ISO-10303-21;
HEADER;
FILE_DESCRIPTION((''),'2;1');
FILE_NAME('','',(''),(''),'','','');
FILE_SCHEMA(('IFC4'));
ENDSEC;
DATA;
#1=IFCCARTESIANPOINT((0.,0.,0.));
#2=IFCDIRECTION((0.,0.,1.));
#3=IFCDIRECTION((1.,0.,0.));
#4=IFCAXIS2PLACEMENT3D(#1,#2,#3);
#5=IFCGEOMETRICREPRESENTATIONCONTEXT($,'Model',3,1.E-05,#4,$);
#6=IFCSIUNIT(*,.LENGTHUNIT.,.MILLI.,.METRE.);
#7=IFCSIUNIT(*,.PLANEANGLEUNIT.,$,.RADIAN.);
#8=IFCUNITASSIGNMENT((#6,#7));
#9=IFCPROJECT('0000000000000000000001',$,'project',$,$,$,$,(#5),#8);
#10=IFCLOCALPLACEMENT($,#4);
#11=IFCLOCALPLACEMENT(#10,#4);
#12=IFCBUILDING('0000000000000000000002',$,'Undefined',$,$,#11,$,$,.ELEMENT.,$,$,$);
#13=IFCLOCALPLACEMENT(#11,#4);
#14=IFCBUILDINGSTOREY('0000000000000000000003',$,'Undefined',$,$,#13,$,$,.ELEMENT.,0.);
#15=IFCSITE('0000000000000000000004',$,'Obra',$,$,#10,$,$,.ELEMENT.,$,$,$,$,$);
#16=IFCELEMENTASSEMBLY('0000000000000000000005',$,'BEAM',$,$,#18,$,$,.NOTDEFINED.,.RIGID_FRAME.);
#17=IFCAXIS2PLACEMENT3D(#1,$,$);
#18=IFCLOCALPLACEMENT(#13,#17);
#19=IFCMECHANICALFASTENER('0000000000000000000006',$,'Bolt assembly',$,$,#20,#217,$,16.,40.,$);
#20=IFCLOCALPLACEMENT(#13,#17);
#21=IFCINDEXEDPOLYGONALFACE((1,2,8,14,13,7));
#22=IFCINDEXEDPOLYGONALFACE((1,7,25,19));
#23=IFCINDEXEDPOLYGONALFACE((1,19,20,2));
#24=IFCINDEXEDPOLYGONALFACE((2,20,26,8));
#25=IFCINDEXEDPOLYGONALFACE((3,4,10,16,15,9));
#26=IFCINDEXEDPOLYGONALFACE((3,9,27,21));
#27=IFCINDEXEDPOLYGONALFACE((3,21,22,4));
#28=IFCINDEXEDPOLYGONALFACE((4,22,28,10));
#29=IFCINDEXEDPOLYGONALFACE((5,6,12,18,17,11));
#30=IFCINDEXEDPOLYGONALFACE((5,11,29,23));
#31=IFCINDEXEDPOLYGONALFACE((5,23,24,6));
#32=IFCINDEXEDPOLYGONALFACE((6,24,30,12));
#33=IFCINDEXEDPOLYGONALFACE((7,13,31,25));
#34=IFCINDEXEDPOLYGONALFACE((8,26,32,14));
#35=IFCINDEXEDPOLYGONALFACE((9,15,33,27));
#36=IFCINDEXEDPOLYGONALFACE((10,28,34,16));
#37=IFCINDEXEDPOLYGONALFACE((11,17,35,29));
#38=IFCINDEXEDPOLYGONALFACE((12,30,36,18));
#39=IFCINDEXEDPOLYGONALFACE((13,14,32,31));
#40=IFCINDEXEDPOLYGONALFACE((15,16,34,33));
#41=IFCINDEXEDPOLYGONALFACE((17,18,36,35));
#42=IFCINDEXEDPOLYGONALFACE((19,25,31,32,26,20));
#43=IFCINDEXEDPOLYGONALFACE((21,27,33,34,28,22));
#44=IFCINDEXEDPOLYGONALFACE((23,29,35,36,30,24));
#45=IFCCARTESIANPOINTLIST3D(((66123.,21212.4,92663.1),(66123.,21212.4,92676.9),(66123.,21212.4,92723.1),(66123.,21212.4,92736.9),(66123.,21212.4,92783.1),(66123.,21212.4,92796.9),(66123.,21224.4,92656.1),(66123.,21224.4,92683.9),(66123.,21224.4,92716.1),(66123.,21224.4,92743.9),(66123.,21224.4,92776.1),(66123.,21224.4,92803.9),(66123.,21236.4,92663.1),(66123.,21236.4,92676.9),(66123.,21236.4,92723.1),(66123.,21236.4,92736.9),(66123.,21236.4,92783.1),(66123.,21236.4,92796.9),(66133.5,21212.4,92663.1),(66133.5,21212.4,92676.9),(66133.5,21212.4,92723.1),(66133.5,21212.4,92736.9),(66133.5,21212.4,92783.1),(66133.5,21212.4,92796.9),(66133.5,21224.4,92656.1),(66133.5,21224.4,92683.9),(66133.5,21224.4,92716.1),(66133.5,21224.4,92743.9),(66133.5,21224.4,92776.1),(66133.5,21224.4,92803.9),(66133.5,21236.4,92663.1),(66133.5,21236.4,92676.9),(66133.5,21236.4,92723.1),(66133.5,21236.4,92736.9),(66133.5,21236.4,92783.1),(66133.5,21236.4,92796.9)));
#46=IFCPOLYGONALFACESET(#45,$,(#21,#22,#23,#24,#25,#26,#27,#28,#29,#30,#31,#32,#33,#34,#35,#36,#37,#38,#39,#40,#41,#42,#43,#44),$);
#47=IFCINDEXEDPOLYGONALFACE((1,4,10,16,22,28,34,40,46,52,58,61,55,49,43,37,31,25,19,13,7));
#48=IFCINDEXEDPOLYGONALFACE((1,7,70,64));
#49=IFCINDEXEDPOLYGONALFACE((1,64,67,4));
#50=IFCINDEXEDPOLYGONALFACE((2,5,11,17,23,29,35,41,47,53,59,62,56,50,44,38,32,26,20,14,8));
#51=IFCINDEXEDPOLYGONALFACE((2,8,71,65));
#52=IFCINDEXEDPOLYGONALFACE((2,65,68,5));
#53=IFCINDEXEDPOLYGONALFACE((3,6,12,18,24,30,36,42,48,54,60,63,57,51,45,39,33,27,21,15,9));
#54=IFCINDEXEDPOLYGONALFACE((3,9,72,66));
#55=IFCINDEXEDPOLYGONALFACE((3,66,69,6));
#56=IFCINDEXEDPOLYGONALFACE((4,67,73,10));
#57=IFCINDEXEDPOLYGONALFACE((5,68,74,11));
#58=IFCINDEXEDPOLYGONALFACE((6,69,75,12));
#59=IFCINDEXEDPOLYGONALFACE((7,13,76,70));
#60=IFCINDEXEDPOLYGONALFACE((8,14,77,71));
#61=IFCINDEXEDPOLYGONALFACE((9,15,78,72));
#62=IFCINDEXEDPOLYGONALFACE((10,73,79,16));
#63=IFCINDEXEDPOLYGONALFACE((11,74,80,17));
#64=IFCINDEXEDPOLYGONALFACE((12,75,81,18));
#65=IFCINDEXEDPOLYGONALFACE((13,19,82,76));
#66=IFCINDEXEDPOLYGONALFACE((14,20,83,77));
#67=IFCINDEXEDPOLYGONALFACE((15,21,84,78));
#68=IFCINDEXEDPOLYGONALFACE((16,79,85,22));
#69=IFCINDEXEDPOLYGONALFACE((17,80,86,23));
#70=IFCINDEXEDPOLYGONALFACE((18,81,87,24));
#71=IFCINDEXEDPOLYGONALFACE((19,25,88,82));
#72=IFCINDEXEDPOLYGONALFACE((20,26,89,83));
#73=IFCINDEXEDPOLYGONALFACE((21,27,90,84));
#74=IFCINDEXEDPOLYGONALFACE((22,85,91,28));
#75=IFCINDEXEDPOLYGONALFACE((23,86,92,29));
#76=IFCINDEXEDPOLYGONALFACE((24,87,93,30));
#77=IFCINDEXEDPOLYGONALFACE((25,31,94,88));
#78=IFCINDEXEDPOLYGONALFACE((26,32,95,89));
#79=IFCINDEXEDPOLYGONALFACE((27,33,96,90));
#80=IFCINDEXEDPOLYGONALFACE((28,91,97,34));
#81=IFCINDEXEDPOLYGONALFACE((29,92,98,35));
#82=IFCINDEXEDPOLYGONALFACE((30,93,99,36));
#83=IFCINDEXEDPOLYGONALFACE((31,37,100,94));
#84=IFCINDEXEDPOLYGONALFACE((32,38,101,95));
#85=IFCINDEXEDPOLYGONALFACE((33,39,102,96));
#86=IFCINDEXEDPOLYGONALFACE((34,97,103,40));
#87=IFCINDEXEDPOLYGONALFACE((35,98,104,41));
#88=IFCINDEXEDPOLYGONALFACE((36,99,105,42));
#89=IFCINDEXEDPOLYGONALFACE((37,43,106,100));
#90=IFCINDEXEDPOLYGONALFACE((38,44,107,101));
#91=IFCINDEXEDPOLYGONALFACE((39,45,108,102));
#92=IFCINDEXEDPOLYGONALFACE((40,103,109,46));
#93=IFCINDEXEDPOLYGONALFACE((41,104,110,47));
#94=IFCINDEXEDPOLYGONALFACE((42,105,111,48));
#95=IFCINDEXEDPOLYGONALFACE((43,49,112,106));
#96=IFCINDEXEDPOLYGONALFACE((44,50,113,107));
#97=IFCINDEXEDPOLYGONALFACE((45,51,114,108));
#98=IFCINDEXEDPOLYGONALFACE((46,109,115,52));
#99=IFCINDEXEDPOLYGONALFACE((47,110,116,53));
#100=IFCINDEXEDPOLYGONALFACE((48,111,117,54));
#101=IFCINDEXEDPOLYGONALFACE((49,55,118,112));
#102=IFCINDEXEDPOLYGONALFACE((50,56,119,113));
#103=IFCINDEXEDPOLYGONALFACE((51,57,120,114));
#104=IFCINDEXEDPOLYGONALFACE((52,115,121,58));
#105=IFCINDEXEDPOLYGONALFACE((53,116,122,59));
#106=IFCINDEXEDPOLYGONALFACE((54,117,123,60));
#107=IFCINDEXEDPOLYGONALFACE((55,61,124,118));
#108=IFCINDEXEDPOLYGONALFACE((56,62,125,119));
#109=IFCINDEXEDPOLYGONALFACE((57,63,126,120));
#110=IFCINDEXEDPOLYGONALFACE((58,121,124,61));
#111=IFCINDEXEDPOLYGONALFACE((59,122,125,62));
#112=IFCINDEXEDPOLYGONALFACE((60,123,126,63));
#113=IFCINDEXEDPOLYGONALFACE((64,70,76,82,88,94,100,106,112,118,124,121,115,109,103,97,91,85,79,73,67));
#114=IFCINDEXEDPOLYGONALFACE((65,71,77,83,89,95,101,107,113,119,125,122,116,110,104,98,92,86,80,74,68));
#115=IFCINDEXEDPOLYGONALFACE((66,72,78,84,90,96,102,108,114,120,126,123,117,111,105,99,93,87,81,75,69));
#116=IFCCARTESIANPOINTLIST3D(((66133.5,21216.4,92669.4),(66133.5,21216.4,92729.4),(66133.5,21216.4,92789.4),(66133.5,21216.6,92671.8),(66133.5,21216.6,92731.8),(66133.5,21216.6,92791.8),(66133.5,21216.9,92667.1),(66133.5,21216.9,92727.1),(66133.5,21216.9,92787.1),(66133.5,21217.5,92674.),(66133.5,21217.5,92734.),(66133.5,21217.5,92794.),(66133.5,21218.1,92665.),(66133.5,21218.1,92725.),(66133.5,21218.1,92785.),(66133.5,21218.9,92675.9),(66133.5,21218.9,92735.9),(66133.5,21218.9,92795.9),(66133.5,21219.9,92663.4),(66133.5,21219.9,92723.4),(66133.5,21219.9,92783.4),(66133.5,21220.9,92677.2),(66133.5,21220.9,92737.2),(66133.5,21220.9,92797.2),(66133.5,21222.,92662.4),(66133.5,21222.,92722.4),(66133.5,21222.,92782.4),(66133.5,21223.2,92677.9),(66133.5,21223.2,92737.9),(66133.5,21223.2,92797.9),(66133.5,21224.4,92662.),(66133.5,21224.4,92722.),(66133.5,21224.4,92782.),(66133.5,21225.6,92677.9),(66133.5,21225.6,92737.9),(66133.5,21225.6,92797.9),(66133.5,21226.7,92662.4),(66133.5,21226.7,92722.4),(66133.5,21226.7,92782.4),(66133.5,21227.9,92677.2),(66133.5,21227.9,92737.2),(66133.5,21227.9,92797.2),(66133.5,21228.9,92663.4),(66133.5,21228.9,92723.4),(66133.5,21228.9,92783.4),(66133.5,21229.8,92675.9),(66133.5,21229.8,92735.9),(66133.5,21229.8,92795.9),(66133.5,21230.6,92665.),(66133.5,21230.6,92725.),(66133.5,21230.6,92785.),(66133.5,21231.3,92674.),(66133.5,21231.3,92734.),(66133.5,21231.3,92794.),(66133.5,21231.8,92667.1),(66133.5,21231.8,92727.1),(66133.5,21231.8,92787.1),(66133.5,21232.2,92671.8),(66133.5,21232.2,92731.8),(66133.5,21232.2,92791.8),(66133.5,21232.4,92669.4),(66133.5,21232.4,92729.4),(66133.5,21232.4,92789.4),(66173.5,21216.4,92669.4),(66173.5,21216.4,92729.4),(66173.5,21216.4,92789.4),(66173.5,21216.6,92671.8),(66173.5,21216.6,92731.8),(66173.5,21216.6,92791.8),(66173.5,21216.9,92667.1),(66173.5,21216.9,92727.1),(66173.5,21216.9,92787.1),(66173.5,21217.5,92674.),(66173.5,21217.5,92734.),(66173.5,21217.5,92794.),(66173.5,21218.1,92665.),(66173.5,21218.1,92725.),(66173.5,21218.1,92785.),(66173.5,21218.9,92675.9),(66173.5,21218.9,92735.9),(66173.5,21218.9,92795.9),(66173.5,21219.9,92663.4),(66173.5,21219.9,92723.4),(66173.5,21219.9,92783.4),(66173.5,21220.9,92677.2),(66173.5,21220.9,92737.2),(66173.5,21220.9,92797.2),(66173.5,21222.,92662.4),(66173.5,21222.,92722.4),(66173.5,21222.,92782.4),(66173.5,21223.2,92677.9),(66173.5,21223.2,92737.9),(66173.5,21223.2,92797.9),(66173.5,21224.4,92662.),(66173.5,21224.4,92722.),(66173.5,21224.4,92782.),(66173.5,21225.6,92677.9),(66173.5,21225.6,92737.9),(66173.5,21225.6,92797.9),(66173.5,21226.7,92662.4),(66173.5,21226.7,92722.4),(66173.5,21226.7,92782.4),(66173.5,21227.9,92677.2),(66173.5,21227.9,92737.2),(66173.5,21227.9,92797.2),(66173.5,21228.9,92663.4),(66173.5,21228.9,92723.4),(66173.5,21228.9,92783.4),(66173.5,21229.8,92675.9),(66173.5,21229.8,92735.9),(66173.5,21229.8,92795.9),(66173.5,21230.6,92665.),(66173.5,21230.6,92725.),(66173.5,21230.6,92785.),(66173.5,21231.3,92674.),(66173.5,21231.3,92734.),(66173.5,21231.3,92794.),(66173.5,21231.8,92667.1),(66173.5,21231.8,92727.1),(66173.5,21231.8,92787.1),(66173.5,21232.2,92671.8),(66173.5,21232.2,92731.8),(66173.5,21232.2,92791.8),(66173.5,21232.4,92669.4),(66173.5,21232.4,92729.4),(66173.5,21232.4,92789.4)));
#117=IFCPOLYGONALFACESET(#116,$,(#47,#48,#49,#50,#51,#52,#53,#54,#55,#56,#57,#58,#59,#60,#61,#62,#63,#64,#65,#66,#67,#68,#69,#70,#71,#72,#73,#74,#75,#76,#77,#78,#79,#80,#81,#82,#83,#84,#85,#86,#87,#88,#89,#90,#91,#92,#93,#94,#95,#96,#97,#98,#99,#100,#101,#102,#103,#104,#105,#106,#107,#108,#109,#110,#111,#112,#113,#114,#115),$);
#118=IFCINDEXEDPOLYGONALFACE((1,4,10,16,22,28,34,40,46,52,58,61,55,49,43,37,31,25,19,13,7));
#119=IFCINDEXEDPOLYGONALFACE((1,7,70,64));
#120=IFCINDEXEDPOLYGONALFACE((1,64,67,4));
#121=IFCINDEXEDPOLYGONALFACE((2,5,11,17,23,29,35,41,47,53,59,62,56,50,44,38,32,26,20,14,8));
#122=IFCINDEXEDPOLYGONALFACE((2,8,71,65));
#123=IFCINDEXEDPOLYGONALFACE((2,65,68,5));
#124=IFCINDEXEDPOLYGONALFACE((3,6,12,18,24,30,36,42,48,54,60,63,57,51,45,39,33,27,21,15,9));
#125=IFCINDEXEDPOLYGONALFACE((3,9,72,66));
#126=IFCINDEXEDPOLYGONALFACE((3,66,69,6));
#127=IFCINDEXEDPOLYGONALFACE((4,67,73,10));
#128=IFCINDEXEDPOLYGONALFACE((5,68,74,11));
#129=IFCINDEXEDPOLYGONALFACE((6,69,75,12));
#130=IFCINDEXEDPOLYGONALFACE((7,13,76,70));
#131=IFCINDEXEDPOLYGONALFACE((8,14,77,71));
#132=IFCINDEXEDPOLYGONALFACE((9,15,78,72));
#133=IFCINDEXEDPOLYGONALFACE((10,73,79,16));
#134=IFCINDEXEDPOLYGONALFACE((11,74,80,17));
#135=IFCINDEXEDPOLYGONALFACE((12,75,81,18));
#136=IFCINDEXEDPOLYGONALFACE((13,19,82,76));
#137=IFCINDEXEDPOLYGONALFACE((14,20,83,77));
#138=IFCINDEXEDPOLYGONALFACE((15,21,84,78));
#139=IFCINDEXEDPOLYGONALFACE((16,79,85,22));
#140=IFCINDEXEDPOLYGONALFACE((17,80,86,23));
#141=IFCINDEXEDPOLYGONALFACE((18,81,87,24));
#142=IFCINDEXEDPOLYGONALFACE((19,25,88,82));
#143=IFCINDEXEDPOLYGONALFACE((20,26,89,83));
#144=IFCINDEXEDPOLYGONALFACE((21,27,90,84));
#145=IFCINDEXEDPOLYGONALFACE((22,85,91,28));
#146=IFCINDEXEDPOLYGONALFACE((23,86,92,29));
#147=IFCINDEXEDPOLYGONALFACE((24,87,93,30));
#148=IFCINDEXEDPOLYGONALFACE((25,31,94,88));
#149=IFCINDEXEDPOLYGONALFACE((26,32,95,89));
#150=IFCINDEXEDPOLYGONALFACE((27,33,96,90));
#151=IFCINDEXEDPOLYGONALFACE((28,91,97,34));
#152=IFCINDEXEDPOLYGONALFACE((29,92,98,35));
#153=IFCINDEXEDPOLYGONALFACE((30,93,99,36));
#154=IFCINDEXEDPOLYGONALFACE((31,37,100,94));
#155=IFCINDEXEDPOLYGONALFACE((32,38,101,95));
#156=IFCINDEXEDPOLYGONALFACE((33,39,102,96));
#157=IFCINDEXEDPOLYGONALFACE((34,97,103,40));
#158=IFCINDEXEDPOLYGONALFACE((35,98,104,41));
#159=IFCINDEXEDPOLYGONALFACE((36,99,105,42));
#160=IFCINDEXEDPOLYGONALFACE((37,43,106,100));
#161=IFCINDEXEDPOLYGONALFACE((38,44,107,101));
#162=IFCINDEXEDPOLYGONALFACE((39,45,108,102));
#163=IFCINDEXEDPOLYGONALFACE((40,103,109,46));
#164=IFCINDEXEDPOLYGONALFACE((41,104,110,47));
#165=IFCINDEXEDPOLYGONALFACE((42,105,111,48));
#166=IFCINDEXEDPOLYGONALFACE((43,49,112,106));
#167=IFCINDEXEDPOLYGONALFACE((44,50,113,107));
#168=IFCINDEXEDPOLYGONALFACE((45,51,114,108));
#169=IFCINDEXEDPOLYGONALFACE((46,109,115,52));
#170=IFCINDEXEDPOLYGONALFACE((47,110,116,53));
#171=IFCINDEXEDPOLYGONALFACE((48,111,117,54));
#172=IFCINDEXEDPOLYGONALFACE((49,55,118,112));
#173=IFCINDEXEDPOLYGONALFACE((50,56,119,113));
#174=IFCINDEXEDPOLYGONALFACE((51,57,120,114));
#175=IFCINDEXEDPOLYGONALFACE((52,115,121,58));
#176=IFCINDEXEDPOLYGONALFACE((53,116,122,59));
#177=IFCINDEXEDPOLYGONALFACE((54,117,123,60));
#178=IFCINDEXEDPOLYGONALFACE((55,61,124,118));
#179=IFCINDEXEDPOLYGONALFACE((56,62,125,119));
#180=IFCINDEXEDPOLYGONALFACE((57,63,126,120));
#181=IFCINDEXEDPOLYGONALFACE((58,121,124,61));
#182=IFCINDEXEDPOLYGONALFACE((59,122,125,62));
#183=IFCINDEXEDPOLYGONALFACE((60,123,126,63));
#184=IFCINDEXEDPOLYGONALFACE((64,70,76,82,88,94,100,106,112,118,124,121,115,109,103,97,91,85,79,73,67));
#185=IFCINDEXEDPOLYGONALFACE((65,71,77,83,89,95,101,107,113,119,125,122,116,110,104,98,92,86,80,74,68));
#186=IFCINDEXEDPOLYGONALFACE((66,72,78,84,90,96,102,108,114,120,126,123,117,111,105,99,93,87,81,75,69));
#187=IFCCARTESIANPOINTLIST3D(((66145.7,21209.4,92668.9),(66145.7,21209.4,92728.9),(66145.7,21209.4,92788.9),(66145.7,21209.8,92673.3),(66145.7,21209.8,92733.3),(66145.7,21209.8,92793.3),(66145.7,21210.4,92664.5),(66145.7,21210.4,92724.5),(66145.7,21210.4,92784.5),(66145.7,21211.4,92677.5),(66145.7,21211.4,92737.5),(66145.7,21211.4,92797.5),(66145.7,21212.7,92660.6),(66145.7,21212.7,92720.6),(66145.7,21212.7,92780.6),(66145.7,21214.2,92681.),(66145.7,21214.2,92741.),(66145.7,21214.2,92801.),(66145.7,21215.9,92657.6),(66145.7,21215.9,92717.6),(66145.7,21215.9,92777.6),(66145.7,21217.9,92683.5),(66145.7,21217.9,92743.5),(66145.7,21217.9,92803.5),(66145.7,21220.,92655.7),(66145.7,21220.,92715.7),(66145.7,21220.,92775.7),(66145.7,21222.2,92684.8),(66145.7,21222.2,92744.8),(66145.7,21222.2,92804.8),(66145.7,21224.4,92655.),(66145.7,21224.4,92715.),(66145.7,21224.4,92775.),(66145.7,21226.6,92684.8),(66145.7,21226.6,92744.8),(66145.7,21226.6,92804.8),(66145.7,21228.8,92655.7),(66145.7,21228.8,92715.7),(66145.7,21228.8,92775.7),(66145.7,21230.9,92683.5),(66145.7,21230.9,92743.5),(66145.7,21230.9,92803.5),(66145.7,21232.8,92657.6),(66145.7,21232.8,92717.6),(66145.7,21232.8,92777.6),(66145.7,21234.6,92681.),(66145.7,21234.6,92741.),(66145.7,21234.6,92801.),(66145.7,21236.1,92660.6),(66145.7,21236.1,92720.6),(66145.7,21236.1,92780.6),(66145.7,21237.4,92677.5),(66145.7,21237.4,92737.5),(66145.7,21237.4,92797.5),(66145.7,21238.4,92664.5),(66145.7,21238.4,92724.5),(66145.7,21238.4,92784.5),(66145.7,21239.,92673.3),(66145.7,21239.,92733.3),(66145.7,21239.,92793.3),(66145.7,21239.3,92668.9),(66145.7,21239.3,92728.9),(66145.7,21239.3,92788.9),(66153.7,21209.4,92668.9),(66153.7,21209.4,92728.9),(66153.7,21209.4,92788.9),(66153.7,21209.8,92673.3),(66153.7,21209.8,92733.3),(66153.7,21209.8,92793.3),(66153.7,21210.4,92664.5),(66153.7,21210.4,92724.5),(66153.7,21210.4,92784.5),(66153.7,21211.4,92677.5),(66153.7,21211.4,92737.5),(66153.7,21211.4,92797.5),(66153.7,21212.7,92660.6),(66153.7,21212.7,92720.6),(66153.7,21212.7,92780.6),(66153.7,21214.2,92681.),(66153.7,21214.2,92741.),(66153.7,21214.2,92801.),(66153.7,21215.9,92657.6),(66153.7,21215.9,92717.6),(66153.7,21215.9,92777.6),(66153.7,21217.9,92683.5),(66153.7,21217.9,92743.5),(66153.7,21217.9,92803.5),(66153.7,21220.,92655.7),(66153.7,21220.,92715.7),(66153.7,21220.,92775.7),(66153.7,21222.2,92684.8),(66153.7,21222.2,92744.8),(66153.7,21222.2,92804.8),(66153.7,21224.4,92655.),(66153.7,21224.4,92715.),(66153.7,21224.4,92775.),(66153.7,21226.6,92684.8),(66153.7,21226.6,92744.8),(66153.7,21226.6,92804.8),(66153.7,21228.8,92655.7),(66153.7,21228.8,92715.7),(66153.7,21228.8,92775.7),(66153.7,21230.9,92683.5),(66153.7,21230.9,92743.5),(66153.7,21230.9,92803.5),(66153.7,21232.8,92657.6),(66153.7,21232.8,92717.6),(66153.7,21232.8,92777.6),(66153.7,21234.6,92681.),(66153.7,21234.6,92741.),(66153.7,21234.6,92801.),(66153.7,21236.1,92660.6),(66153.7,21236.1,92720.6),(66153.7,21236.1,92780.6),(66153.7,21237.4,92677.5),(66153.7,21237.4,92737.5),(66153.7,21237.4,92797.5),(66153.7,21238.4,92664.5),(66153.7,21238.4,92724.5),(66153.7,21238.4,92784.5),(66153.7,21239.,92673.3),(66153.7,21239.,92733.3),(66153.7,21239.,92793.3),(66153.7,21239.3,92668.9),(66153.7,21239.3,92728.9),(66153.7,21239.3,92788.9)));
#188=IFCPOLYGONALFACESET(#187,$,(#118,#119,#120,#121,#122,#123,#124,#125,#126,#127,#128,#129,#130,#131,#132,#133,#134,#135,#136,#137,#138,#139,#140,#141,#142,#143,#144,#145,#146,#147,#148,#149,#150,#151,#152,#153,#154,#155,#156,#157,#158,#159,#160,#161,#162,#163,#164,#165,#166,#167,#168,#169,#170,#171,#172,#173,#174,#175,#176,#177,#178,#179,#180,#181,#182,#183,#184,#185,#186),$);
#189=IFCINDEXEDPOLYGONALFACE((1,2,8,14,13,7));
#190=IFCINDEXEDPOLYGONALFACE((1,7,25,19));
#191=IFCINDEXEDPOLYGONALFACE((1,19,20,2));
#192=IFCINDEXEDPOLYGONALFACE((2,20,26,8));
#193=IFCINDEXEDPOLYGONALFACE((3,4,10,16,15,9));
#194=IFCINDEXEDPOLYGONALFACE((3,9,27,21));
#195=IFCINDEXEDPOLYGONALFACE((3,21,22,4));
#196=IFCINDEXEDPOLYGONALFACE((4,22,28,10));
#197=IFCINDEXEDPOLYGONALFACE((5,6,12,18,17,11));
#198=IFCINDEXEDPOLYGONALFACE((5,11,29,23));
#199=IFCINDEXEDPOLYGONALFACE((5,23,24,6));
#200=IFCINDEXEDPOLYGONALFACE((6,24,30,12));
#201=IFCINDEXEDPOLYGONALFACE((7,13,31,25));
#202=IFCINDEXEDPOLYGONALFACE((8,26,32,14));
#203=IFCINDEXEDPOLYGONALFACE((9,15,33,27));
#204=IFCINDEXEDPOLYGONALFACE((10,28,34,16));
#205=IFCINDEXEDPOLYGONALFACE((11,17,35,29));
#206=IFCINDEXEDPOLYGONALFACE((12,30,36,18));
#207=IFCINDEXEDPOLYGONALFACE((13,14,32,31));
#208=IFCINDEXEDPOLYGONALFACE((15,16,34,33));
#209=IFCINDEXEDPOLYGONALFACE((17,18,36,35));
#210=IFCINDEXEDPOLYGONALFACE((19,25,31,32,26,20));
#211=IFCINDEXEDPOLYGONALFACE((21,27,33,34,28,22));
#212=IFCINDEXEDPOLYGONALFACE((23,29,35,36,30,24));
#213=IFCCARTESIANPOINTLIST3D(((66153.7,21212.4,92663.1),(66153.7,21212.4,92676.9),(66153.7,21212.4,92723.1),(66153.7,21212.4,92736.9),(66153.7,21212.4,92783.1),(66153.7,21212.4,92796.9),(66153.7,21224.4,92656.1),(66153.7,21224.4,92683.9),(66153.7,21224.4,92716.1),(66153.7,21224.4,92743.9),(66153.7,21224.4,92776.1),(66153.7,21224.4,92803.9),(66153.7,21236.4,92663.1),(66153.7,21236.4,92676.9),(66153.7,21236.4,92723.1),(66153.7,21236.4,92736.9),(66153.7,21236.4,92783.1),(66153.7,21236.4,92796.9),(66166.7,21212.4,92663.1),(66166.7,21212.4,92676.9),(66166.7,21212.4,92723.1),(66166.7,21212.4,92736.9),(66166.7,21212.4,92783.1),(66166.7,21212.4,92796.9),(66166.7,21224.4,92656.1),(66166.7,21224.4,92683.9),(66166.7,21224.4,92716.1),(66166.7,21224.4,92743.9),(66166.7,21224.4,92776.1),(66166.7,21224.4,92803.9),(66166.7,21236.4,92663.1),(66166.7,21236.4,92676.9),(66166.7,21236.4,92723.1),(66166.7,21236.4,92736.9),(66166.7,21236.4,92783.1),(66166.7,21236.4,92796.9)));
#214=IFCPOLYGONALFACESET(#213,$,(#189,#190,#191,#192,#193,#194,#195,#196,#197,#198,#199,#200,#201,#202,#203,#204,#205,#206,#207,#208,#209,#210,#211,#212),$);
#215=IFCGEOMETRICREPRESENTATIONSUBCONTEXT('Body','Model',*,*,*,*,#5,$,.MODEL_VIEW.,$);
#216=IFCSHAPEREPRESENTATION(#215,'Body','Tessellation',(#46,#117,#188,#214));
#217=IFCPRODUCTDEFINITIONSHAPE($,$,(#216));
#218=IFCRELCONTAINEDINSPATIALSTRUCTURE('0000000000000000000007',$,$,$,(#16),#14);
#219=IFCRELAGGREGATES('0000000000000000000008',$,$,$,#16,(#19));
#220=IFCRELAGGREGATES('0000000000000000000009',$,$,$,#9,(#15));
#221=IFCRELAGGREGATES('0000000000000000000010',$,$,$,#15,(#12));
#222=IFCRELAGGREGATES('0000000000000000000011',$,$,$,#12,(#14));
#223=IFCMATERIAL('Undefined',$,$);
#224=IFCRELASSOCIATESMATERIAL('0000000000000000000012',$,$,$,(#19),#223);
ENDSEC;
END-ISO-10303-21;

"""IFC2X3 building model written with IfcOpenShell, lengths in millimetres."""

from ifc_helpers import new_model, si_unit, frame, origin_with_axes, origin_2d_with_axis, place, context, subcontext, project, spatial, polyline, circle, outline, extrude, source, transform, mapped, material, element, aggregate, save


model = new_model("IFC2X3")

# Units and contexts
model_context = context("Model", 3, precision=1e-05, world=origin_with_axes())
body_context = subcontext(model_context, "Body", "Model", "MODEL_VIEW")
ifc_project = project(units=[si_unit("LENGTHUNIT", "METRE", prefix="MILLI"), si_unit("PLANEANGLEUNIT", "RADIAN")], contexts=[model_context])

# Site, building, storey
site_placement = place(None, origin_with_axes())
site = spatial("IfcSite", under=ifc_project, at=site_placement, Name="Obra", CompositionType="ELEMENT")
building_placement = place(site_placement, origin_with_axes())
building = spatial("IfcBuilding", under=site, at=building_placement, Name="Undefined", CompositionType="ELEMENT")
storey_placement = place(building_placement, origin_with_axes())
storey = spatial("IfcBuildingStorey", under=building, at=storey_placement, Name="Undefined", CompositionType="ELEMENT", Elevation=0.0)

# Shared definitions
ifc_material_1 = material(Name="Undefined")

# Element assembly
assembly_1_placement = place(storey_placement, origin_with_axes())
assembly_1 = element("IfcElementAssembly", 1, at=assembly_1_placement, inside=storey, Name="BEAM", AssemblyPlace="NOTDEFINED", PredefinedType="RIGID_FRAME")
shared_shape_1 = source(origin_with_axes(), body_context, "Body", "SweptSolid", [
    extrude(outline(polyline([(13.9, 0.0), (6.9, 12.0), (-6.9, 12.0), (-13.9, 0.0), (-6.9, -12.0), (6.9, -12.0), (13.9, 0.0)])), frame((0.0, -19.7, 0.0), z_axis=(0.0, 1.0, 0.0), x_axis=(1.0, 0.0, 0.0)), (0.0, 0.0, 1.0), 10.6),
    extrude(circle(Radius=8.0, at=origin_2d_with_axis()), frame((0.0, -9.1, 0.0), z_axis=(0.0, 1.0, 0.0), x_axis=(1.0, 0.0, 0.0)), (0.0, 0.0, 1.0), 40.0),
    extrude(circle(Radius=15.0, at=origin_2d_with_axis()), frame((0.0, 3.1, 0.0), z_axis=(0.0, 1.0, 0.0), x_axis=(1.0, 0.0, 0.0)), (0.0, 0.0, 1.0), 8.0),
    extrude(outline(polyline([(13.9, 0.0), (6.9, 12.0), (-6.9, 12.0), (-13.9, 0.0), (-6.9, -12.0), (6.9, -12.0), (13.9, 0.0)])), frame((0.0, 11.1, 0.0), z_axis=(0.0, 1.0, 0.0), x_axis=(1.0, 0.0, 0.0)), (0.0, 0.0, 1.0), 13.0),
])

# Mechanical fastener
mechanical_fastener_1_placement = place(assembly_1_placement, frame((66142.6, 21274.4, 92850.0), z_axis=(0.000002, -1.0, 0.0), x_axis=(0.0, 0.0, -1.0)))
mechanical_fastener_1 = element("IfcMechanicalFastener", 2, at=mechanical_fastener_1_placement, material=ifc_material_1, Name="Bolt assembly", NominalDiameter=16.0, NominalLength=40.0, context=body_context, shape_type="MappedRepresentation", body=[
    mapped(shared_shape_1, transform((60.0, 0.0, 50.0))),
    mapped(shared_shape_1, transform((120.0, 0.0, 50.0))),
    mapped(shared_shape_1, transform((180.0, 0.0, 50.0))),
])
aggregate(assembly_1, [mechanical_fastener_1])

save(model, "model.ifc")
